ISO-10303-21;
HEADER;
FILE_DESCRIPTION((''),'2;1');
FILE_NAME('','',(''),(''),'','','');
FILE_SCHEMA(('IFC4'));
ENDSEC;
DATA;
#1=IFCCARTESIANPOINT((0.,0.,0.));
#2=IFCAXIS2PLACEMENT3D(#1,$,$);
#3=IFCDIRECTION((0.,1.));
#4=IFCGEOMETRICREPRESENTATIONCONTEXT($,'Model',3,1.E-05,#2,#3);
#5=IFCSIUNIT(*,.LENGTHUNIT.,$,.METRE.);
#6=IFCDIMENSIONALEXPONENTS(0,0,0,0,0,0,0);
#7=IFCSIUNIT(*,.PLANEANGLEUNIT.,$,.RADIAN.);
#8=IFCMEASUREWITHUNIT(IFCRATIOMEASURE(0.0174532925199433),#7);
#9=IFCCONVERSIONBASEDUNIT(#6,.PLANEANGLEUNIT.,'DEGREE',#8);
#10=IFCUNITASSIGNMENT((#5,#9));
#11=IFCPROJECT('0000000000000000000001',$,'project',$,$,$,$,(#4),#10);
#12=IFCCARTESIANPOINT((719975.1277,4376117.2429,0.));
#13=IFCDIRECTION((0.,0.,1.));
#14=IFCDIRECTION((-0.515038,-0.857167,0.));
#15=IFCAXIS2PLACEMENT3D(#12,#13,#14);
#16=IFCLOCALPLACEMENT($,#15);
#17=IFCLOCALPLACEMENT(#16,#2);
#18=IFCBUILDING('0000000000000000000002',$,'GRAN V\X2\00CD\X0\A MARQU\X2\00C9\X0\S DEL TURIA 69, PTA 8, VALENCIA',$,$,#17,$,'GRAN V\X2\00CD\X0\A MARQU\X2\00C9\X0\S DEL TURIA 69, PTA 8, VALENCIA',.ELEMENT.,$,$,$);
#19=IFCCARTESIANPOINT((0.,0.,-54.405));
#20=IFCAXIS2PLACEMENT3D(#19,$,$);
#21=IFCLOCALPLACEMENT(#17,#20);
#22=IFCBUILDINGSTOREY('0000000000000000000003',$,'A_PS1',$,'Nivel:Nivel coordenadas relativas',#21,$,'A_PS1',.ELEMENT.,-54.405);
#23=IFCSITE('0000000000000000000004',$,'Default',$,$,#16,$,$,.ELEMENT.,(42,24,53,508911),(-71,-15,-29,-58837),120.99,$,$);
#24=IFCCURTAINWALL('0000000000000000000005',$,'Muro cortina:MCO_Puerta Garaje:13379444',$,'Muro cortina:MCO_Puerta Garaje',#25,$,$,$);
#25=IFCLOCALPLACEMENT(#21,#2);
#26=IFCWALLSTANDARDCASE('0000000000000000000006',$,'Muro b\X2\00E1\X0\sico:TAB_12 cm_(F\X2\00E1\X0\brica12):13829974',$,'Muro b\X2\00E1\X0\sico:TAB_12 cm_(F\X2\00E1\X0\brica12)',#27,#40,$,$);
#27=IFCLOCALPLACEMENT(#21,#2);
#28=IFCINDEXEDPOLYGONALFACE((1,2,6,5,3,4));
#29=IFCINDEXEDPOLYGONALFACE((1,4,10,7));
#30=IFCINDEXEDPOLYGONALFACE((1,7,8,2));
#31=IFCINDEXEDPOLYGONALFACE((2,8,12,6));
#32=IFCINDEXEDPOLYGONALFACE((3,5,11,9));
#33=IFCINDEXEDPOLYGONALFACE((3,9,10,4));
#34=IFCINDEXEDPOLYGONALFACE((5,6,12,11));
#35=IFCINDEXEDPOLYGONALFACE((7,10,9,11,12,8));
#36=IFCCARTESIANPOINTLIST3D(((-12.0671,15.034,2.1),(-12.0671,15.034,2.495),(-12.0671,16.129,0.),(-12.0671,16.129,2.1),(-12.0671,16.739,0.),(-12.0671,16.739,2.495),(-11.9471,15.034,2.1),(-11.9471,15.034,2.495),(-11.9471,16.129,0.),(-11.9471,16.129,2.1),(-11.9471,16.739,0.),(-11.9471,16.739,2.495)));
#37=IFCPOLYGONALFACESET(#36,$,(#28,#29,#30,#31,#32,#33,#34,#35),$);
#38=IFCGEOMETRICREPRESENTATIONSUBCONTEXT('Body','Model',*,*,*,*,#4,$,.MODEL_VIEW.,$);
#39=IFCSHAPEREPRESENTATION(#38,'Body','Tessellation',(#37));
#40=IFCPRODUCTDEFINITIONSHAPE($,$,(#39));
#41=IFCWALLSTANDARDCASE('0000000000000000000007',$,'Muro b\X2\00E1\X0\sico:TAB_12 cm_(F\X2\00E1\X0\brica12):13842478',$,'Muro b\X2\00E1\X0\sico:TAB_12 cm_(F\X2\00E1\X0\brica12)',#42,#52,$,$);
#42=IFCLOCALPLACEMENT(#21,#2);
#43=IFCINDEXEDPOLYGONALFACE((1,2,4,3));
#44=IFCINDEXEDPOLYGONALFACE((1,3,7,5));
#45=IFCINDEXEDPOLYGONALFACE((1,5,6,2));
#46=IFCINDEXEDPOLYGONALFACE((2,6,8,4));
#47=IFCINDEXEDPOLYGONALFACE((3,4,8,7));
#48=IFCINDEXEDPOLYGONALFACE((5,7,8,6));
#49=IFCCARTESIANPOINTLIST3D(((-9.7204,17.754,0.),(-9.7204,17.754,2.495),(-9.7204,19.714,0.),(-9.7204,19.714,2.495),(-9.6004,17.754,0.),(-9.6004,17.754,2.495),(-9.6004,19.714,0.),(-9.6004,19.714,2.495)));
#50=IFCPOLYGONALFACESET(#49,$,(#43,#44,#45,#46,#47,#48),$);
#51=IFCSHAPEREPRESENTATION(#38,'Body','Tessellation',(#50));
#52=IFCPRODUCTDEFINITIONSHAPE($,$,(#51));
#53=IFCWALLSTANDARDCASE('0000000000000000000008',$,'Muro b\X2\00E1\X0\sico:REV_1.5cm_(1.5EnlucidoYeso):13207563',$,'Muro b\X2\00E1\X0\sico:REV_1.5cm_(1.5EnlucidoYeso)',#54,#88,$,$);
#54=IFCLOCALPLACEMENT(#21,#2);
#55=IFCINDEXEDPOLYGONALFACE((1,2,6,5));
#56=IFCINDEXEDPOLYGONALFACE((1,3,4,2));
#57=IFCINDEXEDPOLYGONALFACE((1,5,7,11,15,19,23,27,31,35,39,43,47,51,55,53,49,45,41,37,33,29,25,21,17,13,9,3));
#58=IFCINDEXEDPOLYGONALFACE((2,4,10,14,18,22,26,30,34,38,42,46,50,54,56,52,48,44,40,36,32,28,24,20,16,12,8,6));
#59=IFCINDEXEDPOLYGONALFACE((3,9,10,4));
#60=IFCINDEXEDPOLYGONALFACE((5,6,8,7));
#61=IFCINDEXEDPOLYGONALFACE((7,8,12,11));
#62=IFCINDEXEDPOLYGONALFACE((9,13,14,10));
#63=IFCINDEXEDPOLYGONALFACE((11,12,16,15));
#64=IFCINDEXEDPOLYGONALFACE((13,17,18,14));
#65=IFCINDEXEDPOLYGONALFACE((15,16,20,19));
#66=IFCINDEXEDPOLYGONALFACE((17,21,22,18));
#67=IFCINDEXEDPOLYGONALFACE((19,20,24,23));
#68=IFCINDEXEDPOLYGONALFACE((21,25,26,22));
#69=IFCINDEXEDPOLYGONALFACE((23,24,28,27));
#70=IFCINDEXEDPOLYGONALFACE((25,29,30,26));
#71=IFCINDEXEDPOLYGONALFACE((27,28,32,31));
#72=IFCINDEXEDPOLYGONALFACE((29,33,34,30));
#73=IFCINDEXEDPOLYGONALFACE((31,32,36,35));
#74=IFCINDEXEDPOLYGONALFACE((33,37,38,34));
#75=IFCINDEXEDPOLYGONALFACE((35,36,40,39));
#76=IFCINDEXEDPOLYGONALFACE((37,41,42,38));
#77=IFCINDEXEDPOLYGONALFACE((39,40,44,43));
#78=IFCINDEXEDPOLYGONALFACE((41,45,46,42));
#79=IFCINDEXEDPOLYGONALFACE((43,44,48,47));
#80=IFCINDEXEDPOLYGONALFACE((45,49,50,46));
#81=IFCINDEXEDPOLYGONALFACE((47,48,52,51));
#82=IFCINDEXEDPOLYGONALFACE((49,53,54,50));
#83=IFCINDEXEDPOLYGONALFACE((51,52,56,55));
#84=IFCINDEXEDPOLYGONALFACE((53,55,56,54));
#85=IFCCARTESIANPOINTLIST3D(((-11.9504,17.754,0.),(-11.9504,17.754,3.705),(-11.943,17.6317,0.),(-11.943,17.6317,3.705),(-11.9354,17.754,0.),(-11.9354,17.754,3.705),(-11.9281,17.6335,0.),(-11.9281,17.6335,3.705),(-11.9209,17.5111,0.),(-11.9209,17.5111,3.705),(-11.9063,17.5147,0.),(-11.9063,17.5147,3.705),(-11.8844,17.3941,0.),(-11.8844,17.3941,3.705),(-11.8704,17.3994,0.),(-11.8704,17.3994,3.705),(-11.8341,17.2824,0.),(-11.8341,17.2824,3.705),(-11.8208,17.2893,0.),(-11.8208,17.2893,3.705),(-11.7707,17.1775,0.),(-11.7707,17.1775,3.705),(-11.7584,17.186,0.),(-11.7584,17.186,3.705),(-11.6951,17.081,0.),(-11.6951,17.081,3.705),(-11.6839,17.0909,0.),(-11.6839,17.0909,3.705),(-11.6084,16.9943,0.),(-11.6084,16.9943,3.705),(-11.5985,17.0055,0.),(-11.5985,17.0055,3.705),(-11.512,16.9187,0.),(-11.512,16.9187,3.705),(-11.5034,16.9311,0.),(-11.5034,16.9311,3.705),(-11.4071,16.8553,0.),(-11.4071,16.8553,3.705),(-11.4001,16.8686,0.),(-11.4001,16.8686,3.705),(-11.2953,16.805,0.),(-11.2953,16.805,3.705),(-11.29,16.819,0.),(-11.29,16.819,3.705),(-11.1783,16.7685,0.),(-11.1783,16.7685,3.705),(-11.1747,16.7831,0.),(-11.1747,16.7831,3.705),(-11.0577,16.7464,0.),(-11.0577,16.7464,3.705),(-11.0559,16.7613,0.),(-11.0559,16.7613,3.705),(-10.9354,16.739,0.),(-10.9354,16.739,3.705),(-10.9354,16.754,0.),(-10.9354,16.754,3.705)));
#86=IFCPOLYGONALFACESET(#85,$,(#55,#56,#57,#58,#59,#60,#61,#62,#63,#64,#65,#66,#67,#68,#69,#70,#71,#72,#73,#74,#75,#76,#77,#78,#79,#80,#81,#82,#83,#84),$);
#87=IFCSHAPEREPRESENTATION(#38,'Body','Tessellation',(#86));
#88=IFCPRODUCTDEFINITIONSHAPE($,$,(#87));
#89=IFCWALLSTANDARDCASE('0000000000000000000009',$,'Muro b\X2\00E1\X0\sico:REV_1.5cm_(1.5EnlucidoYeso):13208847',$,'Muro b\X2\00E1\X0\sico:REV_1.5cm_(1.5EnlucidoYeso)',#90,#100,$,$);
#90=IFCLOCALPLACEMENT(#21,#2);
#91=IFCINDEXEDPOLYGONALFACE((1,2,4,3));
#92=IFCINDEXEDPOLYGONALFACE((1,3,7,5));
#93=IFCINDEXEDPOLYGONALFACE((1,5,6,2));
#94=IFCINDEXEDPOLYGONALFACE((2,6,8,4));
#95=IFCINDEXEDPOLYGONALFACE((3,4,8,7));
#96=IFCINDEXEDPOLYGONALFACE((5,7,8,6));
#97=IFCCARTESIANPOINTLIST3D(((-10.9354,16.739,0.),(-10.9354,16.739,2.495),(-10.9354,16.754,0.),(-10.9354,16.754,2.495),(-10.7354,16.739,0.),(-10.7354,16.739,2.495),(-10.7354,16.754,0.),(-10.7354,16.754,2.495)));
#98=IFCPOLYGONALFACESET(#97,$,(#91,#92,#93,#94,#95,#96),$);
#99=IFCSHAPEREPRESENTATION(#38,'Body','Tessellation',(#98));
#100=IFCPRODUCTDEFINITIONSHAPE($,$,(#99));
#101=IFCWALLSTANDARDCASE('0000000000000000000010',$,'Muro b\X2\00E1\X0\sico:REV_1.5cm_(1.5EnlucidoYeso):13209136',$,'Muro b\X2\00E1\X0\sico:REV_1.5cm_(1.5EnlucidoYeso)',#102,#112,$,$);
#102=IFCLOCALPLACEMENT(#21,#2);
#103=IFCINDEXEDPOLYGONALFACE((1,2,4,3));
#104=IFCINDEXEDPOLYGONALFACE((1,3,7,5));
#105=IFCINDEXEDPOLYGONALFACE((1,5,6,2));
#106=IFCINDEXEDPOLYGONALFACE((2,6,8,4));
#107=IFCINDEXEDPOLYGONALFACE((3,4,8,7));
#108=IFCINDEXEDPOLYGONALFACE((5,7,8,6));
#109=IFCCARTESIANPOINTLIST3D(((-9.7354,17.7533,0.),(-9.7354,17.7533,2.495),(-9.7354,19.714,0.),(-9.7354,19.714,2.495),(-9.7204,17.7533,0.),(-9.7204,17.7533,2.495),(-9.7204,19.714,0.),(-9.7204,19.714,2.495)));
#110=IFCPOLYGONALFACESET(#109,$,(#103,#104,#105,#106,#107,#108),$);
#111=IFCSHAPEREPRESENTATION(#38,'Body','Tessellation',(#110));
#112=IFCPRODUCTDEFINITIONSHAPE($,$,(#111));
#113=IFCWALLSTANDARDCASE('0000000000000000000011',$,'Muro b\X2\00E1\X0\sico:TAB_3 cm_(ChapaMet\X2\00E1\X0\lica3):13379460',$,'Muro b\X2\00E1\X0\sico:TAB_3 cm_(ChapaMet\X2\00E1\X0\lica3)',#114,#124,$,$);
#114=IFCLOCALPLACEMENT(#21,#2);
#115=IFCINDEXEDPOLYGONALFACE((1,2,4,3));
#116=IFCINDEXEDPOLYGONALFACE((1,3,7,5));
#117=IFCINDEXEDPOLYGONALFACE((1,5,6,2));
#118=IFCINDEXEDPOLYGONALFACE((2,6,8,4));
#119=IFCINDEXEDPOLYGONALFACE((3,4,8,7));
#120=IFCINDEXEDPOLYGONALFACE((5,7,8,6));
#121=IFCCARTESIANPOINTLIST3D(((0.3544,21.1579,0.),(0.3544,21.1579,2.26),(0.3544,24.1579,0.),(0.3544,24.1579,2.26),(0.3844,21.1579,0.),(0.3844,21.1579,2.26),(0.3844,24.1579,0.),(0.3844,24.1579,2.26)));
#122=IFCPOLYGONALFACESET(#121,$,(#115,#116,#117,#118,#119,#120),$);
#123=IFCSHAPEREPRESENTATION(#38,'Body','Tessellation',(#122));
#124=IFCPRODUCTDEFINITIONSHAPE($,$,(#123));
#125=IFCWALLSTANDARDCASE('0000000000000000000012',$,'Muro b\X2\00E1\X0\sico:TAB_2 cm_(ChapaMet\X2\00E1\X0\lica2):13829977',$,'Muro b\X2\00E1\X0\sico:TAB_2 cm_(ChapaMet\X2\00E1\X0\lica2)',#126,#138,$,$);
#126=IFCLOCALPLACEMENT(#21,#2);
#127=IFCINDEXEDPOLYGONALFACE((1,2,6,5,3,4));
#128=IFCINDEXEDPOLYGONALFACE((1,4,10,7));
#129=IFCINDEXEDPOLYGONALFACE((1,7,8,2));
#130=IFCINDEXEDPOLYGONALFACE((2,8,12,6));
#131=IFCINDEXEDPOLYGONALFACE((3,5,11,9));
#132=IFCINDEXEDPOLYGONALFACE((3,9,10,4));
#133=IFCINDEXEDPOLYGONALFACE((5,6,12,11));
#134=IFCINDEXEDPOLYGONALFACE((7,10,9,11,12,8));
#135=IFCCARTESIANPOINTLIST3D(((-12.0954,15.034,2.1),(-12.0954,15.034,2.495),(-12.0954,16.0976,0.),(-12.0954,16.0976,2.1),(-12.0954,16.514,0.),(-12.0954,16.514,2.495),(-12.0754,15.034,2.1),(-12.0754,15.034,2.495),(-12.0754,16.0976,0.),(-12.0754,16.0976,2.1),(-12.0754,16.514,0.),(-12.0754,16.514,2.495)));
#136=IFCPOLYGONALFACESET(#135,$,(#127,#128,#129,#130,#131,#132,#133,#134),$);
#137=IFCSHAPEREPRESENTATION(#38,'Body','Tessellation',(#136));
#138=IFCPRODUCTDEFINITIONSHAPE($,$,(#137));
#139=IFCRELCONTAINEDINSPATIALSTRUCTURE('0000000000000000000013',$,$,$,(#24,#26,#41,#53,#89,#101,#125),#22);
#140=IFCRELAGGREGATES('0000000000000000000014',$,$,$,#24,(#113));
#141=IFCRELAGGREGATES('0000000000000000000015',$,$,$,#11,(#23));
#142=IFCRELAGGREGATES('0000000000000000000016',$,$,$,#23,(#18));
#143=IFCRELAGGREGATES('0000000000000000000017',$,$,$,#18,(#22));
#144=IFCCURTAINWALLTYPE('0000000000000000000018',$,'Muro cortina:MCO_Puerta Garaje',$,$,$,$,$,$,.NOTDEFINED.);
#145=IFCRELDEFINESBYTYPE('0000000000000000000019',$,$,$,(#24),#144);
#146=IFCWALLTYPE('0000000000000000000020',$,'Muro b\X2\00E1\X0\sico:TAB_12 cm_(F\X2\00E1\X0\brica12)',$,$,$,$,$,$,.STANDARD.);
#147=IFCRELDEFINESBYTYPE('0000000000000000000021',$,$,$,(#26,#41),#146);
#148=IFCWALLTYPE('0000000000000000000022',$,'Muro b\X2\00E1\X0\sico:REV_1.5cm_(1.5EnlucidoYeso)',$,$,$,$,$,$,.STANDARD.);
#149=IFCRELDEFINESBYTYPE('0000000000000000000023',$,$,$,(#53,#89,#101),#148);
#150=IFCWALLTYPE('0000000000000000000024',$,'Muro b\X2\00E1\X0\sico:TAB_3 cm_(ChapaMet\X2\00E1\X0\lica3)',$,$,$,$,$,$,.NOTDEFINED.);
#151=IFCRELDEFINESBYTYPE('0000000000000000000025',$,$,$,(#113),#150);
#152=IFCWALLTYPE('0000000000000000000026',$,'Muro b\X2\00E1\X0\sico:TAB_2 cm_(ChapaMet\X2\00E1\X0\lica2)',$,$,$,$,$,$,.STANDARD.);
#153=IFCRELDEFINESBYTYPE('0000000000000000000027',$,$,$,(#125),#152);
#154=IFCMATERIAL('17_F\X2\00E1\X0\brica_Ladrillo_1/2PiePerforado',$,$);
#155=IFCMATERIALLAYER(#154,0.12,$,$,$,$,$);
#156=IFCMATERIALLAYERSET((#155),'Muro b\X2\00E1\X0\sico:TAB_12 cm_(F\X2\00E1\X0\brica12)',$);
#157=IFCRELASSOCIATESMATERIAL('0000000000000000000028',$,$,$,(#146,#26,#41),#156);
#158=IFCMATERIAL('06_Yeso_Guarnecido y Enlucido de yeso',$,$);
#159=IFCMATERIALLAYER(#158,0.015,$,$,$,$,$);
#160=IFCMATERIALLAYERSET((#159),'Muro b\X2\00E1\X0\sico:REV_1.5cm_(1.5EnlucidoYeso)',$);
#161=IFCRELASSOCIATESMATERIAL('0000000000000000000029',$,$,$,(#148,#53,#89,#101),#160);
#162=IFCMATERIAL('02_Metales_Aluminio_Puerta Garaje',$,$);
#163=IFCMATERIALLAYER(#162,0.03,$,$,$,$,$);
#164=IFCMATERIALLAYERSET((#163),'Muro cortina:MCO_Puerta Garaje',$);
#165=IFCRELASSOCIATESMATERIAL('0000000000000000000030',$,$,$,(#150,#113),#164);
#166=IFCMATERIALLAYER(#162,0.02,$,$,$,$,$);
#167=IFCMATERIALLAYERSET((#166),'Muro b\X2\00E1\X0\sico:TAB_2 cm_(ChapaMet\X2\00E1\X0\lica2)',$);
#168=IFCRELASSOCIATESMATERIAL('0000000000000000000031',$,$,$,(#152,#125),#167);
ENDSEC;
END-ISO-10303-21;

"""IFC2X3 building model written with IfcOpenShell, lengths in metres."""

from ifc_helpers import new_model, entity, si_unit, converted_unit, direction, frame, frame_2d, origin, place, context, subcontext, project, spatial, polyline, circle_curve, parameter, trimmed, segment, composite_curve, rectangle, outline, extrude, material, layer, layer_set, layer_usage, type_object, element, aggregate, save


model = new_model("IFC2X3")

# Units and contexts
model_context = context("Model", 3, precision=1e-05, world=origin(), true_north=direction((0.0, 1.0)))
body_context = subcontext(model_context, "Body", "Model", "MODEL_VIEW")
ifc_project = project(units=[si_unit("LENGTHUNIT", "METRE"), converted_unit("PLANEANGLEUNIT", "DEGREE", entity("IfcRatioMeasure", 0.0174532925199433), si_unit("PLANEANGLEUNIT", "RADIAN"), dimensions=[0, 0, 0, 0, 0, 0, 0])], contexts=[model_context])

# Site, building, storey
site_placement = place(None, frame((719975.1277, 4376117.2429, 0.0), z_axis=(0.0, 0.0, 1.0), x_axis=(-0.515038, -0.857167, 0.0)))
site = spatial("IfcSite", under=ifc_project, at=site_placement, Name="Default", CompositionType="ELEMENT", RefLatitude=(42, 24, 53, 508911), RefLongitude=(-71, -15, -29, -58837), RefElevation=120.99)
building_placement = place(site_placement, origin())
building = spatial("IfcBuilding", under=site, at=building_placement, Name="GRAN VÍA MARQUÉS DEL TURIA 69, PTA 8, VALENCIA", LongName="GRAN VÍA MARQUÉS DEL TURIA 69, PTA 8, VALENCIA", CompositionType="ELEMENT")
storey_placement = place(building_placement, frame((0.0, 0.0, -54.405)))
storey = spatial("IfcBuildingStorey", under=building, at=storey_placement, Name="A_PS1", ObjectType="Nivel:Nivel coordenadas relativas", LongName="A_PS1", CompositionType="ELEMENT", Elevation=-54.405)

# Curtain wall
curtain_wall_type = type_object("IfcCurtainWallType", Name="Muro cortina:MCO_Puerta Garaje", PredefinedType="NOTDEFINED")
curtain_wall_placement = place(storey_placement, frame((0.0, 0.0, 54.405)))
curtain_wall = element("IfcCurtainWall", 1, at=curtain_wall_placement, inside=storey, type_object=curtain_wall_type, Name="Muro cortina:MCO_Puerta Garaje:13379444", ObjectType="Muro cortina:MCO_Puerta Garaje")

# Shared definitions
ifc_material_1 = material(Name="17_Fábrica_Ladrillo_1/2PiePerforado")
ifc_layer_1 = layer(ifc_material_1, 0.12)
ifc_layer_set_1 = layer_set([ifc_layer_1], Name="Muro básico:TAB_12 cm_(Fábrica12)")
wall_type_1 = type_object("IfcWallType", Name="Muro básico:TAB_12 cm_(Fábrica12)", PredefinedType="STANDARD", material=ifc_layer_set_1)

# Wall, opening
ifc_layer_usage_1 = layer_usage(ifc_layer_set_1, "AXIS2", "POSITIVE", -0.06)
wall_1_placement = place(storey_placement, frame((-12.0071, 15.034, 0.0), z_axis=(0.0, 0.0, 1.0), x_axis=(0.0, 1.0, 0.0)))
wall_1 = element("IfcWallStandardCase", 2, at=wall_1_placement, inside=storey, type_object=wall_type_1, material=ifc_layer_usage_1, Name="Muro básico:TAB_12 cm_(Fábrica12):13829974", ObjectType="Muro básico:TAB_12 cm_(Fábrica12)", context=body_context, shape_type="SweptSolid", body=[
    extrude(rectangle(XDim=1.705, YDim=0.12, at=frame_2d((0.8525, 0.0), x_axis=(-1.0, 0.0))), origin(), (0.0, 0.0, 1.0), 2.495),
])
opening_1_placement = place(wall_1_placement, origin())
element("IfcOpeningElement", 3, at=opening_1_placement, cuts=wall_1, ObjectType="Opening", context=body_context, shape_type="SweptSolid", body=[
    extrude(rectangle(XDim=2.1, YDim=1.1285, at=frame_2d((0.0, 0.0), x_axis=(1.0, 0.0))), frame((0.5308, -0.06, 1.05), z_axis=(0.0, 1.0, 0.0), x_axis=(0.0, 0.0, -1.0)), (0.0, 0.0, 1.0), 0.12),
])

# Walls
ifc_layer_usage_2 = layer_usage(ifc_layer_set_1, "AXIS2", "NEGATIVE", 0.06)
wall_2_placement = place(storey_placement, frame((-9.6604, 17.754, 0.0), z_axis=(0.0, 0.0, 1.0), x_axis=(0.0, 1.0, 0.0)))
element("IfcWallStandardCase", 4, at=wall_2_placement, inside=storey, type_object=wall_type_1, material=ifc_layer_usage_2, Name="Muro básico:TAB_12 cm_(Fábrica12):13842478", ObjectType="Muro básico:TAB_12 cm_(Fábrica12)", context=body_context, shape_type="SweptSolid", body=[
    extrude(rectangle(XDim=1.96, YDim=0.12, at=frame_2d((0.98, 0.0), x_axis=(-1.0, 0.0))), origin(), (0.0, 0.0, 1.0), 2.495),
])
ifc_material_2 = material(Name="06_Yeso_Guarnecido y Enlucido de yeso")
ifc_layer_2 = layer(ifc_material_2, 0.015)
ifc_layer_set_2 = layer_set([ifc_layer_2], Name="Muro básico:REV_1.5cm_(1.5EnlucidoYeso)")
ifc_layer_usage_3 = layer_usage(ifc_layer_set_2, "AXIS2", "NEGATIVE", 0.0075)
wall_type_2 = type_object("IfcWallType", Name="Muro básico:REV_1.5cm_(1.5EnlucidoYeso)", PredefinedType="STANDARD", material=ifc_layer_set_2)
wall_3_placement = place(storey_placement, frame((-11.9429, 17.754, 0.0)))
element("IfcWallStandardCase", 5, at=wall_3_placement, inside=storey, type_object=wall_type_2, material=ifc_layer_usage_3, Name="Muro básico:REV_1.5cm_(1.5EnlucidoYeso):13207563", ObjectType="Muro básico:REV_1.5cm_(1.5EnlucidoYeso)", context=body_context, shape_type="SweptSolid", body=[
    extrude(outline(composite_curve([segment(trimmed(circle_curve(frame_2d((1.0075, 0.0), x_axis=(1.0, 0.0)), 1.0), [parameter(180.0)], [parameter(270.0)], True, "PARAMETER"), False, "CONTINUOUS"), segment(polyline([(0.0075, 0.0), (-0.0075, 0.0)]), True, "CONTINUOUS"), segment(trimmed(circle_curve(frame_2d((1.0075, 0.0), x_axis=(1.0, 0.0)), 1.015), [parameter(180.0)], [parameter(270.0)], True, "PARAMETER"), True, "CONTINUOUS"), segment(polyline([(1.0075, -1.015), (1.0075, -1.0)]), True, "CONTINUOUS")], self_intersect=False)), origin(), (0.0, 0.0, 1.0), 3.705),
])
ifc_layer_usage_4 = layer_usage(ifc_layer_set_2, "AXIS2", "NEGATIVE", 0.0075)
wall_4_placement = place(storey_placement, frame((-10.9354, 16.7465, 0.0)))
element("IfcWallStandardCase", 6, at=wall_4_placement, inside=storey, type_object=wall_type_2, material=ifc_layer_usage_4, Name="Muro básico:REV_1.5cm_(1.5EnlucidoYeso):13208847", ObjectType="Muro básico:REV_1.5cm_(1.5EnlucidoYeso)", context=body_context, shape_type="SweptSolid", body=[
    extrude(rectangle(XDim=0.2, YDim=0.015, at=frame_2d((0.1, 0.0), x_axis=(-1.0, 0.0))), origin(), (0.0, 0.0, 1.0), 2.495),
])
ifc_layer_usage_5 = layer_usage(ifc_layer_set_2, "AXIS2", "NEGATIVE", 0.0075)
wall_5_placement = place(storey_placement, frame((-9.7279, 17.7533, 0.0), z_axis=(0.0, 0.0, 1.0), x_axis=(0.0, 1.0, 0.0)))
element("IfcWallStandardCase", 7, at=wall_5_placement, inside=storey, type_object=wall_type_2, material=ifc_layer_usage_5, Name="Muro básico:REV_1.5cm_(1.5EnlucidoYeso):13209136", ObjectType="Muro básico:REV_1.5cm_(1.5EnlucidoYeso)", context=body_context, shape_type="SweptSolid", body=[
    extrude(rectangle(XDim=1.9607, YDim=0.015, at=frame_2d((0.9804, 0.0), x_axis=(-1.0, 0.0))), origin(), (0.0, 0.0, 1.0), 2.495),
])

# Wall
ifc_material_3 = material(Name="02_Metales_Aluminio_Puerta Garaje")
ifc_layer_3 = layer(ifc_material_3, 0.03)
ifc_layer_set_3 = layer_set([ifc_layer_3], Name="Muro cortina:MCO_Puerta Garaje")
ifc_layer_usage_6 = layer_usage(ifc_layer_set_3, "AXIS2", "NEGATIVE", 0.015)
wall_type_3 = type_object("IfcWallType", Name="Muro básico:TAB_3 cm_(ChapaMetálica3)", PredefinedType="NOTDEFINED", material=ifc_layer_set_3)
wall_6_placement = place(storey_placement, frame((0.3694, 24.1579, 0.0), z_axis=(0.0, 0.0, 1.0), x_axis=(0.0, -1.0, 0.0)))
wall_6 = element("IfcWallStandardCase", 8, at=wall_6_placement, type_object=wall_type_3, material=ifc_layer_usage_6, Name="Muro básico:TAB_3 cm_(ChapaMetálica3):13379460", ObjectType="Muro básico:TAB_3 cm_(ChapaMetálica3)", context=body_context, shape_type="SweptSolid", body=[
    extrude(rectangle(XDim=3.0, YDim=0.03, at=frame_2d((1.5, 0.0), x_axis=(-1.0, 0.0))), origin(), (0.0, 0.0, 1.0), 2.26),
])
aggregate(curtain_wall, [wall_6])

# Wall, opening
ifc_layer_4 = layer(ifc_material_3, 0.02)
ifc_layer_set_4 = layer_set([ifc_layer_4], Name="Muro básico:TAB_2 cm_(ChapaMetálica2)")
ifc_layer_usage_7 = layer_usage(ifc_layer_set_4, "AXIS2", "NEGATIVE", 0.01)
wall_type_4 = type_object("IfcWallType", Name="Muro básico:TAB_2 cm_(ChapaMetálica2)", PredefinedType="STANDARD", material=ifc_layer_set_4)
wall_7_placement = place(storey_placement, frame((-12.0854, 16.514, 0.0), z_axis=(0.0, 0.0, 1.0), x_axis=(0.0, -1.0, 0.0)))
wall_7 = element("IfcWallStandardCase", 9, at=wall_7_placement, inside=storey, type_object=wall_type_4, material=ifc_layer_usage_7, Name="Muro básico:TAB_2 cm_(ChapaMetálica2):13829977", ObjectType="Muro básico:TAB_2 cm_(ChapaMetálica2)", context=body_context, shape_type="SweptSolid", body=[
    extrude(rectangle(XDim=1.48, YDim=0.02, at=frame_2d((0.74, 0.0), x_axis=(-1.0, 0.0))), origin(), (0.0, 0.0, 1.0), 2.495),
])
opening_2_placement = place(wall_7_placement, origin())
element("IfcOpeningElement", 10, at=opening_2_placement, cuts=wall_7, ObjectType="Opening", context=body_context, shape_type="SweptSolid", body=[
    extrude(rectangle(XDim=2.1, YDim=1.0636, at=frame_2d((0.0, 0.0), x_axis=(0.0, 1.0))), frame((0.9482, -1.514, 1.05), z_axis=(0.0, 1.0, 0.0), x_axis=(-1.0, 0.0, 0.0)), (0.0, 0.0, 1.0), 3.048),
])

save(model, "model.ifc")
